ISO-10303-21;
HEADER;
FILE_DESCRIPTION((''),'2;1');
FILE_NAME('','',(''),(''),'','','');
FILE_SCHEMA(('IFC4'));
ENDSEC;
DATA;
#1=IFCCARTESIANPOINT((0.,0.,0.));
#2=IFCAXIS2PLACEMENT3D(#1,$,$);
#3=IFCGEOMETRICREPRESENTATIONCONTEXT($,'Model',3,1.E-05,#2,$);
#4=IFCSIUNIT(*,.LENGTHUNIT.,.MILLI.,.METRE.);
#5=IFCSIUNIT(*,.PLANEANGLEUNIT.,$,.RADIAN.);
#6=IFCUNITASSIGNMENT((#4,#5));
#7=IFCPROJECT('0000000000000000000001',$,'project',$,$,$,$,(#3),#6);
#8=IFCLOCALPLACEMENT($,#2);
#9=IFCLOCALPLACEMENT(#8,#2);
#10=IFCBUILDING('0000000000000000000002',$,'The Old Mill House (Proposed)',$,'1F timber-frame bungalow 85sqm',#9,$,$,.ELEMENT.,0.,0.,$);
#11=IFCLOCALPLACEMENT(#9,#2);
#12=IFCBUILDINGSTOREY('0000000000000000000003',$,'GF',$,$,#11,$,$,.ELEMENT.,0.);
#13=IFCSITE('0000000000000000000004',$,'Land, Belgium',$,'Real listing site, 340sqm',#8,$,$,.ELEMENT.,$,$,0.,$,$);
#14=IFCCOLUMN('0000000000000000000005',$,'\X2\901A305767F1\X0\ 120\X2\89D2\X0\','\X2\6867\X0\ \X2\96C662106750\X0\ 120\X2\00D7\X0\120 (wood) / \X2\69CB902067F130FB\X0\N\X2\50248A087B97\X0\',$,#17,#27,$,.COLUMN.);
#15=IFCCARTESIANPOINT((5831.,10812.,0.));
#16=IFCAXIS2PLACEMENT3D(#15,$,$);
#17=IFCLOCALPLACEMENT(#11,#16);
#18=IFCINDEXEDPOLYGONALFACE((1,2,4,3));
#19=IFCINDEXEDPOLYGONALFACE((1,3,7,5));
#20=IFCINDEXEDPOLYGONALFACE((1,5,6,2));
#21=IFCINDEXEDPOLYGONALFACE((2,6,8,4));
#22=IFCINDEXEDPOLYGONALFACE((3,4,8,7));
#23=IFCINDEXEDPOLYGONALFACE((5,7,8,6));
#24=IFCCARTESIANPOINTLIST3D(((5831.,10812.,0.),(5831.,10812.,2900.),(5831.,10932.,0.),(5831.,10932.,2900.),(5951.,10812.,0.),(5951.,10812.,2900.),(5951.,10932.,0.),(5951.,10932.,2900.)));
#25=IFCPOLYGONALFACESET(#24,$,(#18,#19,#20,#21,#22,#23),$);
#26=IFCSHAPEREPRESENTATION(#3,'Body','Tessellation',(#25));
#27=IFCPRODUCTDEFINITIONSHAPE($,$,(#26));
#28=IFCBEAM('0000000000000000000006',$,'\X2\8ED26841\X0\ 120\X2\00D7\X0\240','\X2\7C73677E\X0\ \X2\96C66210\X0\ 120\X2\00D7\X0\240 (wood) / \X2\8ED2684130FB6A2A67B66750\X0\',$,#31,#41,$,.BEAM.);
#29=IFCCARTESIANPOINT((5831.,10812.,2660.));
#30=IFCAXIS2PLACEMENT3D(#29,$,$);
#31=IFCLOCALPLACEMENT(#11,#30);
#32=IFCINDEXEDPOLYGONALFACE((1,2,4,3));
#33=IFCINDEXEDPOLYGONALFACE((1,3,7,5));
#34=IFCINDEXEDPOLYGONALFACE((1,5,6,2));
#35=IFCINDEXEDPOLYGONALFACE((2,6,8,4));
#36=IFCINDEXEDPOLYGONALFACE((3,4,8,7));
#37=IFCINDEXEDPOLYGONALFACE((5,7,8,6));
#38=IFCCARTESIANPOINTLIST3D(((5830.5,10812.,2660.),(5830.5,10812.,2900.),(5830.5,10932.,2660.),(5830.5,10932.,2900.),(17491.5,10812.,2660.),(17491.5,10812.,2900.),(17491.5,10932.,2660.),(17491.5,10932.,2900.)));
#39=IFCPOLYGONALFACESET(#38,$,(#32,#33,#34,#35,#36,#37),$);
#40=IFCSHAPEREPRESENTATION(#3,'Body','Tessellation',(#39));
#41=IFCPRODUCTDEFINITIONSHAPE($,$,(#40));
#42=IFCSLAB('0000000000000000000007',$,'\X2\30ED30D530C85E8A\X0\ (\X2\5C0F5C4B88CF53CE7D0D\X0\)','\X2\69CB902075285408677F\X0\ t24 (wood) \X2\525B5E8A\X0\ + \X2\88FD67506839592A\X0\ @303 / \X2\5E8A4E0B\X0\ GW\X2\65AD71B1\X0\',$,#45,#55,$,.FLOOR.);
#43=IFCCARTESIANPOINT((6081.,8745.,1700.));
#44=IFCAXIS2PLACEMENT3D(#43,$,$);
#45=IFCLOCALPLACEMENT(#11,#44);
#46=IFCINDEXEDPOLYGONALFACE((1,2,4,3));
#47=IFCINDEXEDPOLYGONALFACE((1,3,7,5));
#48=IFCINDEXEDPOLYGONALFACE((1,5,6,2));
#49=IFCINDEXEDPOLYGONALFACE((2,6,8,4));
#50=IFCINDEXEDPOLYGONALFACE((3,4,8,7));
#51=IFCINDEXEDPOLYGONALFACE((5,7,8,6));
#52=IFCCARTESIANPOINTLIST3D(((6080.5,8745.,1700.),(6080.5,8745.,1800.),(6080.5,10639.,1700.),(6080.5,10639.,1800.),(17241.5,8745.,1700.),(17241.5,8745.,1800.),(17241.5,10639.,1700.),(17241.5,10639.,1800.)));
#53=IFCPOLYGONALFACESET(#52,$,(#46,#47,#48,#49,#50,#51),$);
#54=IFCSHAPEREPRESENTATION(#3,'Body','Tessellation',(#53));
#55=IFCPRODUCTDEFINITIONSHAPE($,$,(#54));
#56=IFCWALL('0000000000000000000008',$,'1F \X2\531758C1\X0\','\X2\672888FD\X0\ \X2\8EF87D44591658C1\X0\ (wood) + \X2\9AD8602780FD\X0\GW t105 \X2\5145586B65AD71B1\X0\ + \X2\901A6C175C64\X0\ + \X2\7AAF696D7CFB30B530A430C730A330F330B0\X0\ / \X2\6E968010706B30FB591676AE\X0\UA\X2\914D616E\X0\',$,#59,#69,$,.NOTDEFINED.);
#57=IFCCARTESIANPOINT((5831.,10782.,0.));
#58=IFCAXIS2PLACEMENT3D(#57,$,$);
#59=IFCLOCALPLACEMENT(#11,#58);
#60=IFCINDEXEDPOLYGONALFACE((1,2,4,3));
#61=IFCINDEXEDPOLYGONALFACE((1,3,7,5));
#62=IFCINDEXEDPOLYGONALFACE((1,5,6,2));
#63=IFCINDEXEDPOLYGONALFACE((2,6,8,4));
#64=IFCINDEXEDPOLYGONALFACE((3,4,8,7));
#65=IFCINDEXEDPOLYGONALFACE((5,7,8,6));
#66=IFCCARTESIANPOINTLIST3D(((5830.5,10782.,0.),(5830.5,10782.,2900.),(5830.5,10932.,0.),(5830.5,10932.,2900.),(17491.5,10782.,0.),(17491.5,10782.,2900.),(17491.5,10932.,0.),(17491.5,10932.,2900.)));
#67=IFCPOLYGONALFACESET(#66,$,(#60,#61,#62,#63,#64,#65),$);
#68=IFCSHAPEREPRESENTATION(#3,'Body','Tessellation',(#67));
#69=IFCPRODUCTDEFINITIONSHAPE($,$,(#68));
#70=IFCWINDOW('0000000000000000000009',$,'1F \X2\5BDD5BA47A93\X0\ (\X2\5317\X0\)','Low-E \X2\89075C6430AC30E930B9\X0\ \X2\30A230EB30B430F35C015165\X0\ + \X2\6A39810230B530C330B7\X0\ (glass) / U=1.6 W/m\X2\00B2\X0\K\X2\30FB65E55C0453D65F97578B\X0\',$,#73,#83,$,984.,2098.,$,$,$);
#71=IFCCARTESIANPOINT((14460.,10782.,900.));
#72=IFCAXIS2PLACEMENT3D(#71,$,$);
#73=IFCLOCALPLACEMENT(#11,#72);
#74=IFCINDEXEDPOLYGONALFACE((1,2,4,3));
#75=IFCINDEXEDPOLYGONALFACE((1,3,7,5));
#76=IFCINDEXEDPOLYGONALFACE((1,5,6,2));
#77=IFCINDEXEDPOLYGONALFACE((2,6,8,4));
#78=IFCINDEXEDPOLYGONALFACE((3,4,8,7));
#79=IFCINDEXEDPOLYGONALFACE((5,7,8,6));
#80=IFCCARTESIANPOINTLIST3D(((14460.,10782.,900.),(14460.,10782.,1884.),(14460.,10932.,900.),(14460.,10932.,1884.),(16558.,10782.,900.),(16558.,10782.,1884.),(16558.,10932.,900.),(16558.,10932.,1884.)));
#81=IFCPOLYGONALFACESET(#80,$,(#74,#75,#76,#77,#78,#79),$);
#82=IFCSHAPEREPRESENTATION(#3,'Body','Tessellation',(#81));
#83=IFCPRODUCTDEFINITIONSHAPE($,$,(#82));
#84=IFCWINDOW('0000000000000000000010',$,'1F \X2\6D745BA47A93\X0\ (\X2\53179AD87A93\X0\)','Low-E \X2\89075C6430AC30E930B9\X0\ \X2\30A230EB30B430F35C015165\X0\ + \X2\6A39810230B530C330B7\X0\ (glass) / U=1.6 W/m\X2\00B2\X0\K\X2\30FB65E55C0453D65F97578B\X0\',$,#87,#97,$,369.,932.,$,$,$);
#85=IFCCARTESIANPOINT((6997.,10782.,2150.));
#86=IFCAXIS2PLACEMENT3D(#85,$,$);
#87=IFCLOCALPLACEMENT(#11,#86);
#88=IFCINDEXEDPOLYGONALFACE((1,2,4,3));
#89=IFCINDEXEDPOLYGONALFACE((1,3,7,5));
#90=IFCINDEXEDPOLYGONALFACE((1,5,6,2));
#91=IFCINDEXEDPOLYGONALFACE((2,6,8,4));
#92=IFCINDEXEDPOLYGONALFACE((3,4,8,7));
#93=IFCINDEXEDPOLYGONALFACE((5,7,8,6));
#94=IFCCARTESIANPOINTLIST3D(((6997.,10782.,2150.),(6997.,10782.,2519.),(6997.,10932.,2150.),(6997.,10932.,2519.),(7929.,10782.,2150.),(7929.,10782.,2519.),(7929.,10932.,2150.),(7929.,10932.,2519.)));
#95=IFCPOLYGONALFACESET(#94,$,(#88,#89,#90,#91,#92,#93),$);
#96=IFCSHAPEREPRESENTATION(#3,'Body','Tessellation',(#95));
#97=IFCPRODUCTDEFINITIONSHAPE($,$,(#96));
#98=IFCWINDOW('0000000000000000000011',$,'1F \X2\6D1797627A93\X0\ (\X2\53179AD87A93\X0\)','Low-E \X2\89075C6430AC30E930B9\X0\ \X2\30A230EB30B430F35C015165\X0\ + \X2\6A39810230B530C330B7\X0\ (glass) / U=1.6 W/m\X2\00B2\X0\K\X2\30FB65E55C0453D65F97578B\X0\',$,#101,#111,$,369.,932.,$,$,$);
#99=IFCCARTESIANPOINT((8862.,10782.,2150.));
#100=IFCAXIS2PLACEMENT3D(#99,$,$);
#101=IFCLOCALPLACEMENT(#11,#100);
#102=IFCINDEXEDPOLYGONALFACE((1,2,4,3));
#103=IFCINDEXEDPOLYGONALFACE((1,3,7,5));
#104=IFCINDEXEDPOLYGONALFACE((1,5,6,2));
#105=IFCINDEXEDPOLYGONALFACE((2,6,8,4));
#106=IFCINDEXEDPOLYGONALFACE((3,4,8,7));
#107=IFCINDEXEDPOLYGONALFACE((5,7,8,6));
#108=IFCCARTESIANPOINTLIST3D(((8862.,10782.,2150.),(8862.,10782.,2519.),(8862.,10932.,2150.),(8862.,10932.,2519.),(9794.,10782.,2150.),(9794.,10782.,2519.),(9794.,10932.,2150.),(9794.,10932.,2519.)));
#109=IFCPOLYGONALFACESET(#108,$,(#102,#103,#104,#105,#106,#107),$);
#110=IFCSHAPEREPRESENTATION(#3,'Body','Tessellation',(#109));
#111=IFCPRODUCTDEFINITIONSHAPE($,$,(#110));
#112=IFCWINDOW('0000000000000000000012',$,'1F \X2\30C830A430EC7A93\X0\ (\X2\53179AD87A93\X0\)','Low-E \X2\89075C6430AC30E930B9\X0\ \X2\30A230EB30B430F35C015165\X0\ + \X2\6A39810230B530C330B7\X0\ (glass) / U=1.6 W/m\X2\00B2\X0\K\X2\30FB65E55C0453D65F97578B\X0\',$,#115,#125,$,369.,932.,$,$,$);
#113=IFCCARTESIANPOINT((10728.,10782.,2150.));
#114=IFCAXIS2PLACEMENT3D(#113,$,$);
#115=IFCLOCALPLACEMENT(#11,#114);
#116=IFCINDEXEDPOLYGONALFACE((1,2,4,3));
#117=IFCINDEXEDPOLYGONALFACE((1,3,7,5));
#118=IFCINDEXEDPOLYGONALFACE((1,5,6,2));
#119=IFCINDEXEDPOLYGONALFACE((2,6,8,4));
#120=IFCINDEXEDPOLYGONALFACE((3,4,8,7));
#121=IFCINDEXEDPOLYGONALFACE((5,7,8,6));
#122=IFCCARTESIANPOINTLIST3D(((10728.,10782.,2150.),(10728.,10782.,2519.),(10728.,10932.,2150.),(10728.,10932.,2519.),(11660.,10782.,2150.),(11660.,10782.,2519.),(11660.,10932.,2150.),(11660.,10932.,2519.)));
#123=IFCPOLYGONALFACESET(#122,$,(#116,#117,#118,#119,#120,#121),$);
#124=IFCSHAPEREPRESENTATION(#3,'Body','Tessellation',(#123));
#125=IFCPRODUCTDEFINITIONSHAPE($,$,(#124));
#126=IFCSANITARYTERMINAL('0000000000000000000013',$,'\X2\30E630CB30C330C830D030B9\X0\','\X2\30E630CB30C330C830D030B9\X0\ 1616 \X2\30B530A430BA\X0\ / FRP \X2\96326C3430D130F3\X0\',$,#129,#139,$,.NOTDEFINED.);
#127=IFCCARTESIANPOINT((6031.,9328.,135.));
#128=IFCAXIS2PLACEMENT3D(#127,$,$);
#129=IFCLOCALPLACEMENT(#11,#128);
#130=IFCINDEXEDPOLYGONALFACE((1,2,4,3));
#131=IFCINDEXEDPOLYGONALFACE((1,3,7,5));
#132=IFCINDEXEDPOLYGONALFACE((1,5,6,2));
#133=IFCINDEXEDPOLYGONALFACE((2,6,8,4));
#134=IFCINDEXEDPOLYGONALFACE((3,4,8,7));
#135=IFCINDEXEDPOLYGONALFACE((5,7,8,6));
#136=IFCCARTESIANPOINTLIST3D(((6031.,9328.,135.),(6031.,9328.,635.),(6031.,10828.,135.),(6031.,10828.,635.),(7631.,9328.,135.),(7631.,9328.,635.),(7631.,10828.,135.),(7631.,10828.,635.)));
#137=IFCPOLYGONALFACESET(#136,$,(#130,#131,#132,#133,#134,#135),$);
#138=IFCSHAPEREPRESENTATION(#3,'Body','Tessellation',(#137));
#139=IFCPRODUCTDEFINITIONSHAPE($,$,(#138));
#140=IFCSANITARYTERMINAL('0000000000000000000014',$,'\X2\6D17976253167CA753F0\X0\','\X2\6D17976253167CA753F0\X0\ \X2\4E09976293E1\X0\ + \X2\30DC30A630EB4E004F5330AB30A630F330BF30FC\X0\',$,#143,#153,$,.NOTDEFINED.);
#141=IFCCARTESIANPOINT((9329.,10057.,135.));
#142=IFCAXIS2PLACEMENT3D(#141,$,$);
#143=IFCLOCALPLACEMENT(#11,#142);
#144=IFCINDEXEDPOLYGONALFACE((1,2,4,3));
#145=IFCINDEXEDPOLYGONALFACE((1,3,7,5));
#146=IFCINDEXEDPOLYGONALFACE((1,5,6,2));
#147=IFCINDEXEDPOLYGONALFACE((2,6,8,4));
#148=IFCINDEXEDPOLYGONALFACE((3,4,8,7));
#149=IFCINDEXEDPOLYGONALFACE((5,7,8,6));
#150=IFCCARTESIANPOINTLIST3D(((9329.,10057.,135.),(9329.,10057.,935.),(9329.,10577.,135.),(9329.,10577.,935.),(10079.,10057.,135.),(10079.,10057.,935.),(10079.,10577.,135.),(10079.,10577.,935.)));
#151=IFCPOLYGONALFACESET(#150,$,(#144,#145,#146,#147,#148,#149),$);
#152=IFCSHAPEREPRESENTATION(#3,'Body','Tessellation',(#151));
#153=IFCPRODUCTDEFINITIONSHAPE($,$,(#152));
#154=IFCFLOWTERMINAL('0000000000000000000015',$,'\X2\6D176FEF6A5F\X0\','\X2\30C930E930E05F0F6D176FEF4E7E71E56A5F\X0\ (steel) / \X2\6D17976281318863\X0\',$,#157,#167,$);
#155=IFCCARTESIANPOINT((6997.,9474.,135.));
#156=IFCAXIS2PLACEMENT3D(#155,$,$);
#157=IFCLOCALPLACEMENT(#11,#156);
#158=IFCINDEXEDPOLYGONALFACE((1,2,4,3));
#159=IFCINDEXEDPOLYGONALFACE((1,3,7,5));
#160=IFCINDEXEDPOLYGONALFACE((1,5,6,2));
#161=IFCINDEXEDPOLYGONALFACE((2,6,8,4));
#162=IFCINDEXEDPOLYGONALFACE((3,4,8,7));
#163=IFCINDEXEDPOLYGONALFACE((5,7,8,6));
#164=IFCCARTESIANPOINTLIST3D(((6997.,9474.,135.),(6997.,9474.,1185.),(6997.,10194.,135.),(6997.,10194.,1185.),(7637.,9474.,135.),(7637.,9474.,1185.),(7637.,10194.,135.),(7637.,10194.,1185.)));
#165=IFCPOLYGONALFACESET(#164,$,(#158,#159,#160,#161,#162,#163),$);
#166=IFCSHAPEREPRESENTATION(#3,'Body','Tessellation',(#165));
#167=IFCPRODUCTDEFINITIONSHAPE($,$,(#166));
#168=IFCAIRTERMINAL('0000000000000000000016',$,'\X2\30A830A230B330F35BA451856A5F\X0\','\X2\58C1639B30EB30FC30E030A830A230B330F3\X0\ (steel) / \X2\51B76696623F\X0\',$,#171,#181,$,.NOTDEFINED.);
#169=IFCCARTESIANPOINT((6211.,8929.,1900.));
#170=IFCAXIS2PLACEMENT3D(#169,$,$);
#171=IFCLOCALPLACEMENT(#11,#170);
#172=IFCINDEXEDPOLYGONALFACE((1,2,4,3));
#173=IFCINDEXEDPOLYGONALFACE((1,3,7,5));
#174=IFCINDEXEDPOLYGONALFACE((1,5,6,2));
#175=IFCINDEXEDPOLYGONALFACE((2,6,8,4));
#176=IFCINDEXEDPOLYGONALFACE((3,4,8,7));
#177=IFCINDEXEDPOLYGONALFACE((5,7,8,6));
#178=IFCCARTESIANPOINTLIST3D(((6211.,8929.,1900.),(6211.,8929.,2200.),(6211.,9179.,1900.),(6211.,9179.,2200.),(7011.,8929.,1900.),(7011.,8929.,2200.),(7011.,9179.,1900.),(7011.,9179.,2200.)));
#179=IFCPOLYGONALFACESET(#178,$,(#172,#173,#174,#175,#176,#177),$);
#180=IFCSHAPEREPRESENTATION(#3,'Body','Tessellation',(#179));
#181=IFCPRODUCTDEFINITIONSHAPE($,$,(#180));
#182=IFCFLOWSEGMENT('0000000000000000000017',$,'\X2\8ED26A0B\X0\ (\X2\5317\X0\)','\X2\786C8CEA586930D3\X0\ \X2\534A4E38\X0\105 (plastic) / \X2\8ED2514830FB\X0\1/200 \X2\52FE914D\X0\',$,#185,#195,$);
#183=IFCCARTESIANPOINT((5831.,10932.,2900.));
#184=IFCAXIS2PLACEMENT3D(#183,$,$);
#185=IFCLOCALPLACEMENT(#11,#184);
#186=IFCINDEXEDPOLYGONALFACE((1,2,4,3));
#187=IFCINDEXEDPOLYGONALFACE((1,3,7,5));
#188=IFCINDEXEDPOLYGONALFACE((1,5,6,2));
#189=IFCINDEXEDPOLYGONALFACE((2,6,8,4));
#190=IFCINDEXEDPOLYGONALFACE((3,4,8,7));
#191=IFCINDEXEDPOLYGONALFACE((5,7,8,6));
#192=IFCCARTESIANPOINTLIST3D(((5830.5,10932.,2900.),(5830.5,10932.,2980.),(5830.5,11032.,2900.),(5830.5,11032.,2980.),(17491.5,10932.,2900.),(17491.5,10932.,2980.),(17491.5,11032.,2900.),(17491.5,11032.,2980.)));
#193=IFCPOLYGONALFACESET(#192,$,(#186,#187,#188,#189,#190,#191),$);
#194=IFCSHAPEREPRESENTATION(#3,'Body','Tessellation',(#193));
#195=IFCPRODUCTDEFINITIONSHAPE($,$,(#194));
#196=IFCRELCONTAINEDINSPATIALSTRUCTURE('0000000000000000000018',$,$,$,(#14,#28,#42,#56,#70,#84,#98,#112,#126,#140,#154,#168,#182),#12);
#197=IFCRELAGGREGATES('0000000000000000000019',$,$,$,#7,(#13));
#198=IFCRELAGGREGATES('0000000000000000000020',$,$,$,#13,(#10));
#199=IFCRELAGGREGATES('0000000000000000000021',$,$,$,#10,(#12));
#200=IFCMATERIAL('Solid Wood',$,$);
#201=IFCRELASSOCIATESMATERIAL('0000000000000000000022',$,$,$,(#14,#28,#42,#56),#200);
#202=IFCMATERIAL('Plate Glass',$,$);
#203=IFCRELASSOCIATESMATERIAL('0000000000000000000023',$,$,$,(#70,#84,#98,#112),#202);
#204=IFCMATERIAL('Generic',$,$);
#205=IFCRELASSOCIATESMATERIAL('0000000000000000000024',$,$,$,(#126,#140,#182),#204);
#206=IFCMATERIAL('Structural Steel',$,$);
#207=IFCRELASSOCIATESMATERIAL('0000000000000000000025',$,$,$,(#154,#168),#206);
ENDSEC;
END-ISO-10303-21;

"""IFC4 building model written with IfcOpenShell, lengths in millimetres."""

from ifc_helpers import new_model, si_unit, frame, frame_2d, origin, place, context, project, spatial, rectangle, extrude, material, element, fill, save


model = new_model("IFC4")

# Units and contexts
model_context = context("Model", 3, precision=1e-05, world=origin())
ifc_project = project(units=[si_unit("LENGTHUNIT", "METRE", prefix="MILLI"), si_unit("PLANEANGLEUNIT", "RADIAN")], contexts=[model_context])

# Site, building, storey
site_placement = place(None, origin())
site = spatial("IfcSite", under=ifc_project, at=site_placement, Name="Land, Belgium", ObjectType="Real listing site, 340sqm", CompositionType="ELEMENT", RefElevation=0.0)
building_placement = place(site_placement, origin())
building = spatial("IfcBuilding", under=site, at=building_placement, Name="The Old Mill House (Proposed)", ObjectType="1F timber-frame bungalow 85sqm", CompositionType="ELEMENT", ElevationOfRefHeight=0.0, ElevationOfTerrain=0.0)
storey_placement = place(building_placement, origin())
storey = spatial("IfcBuildingStorey", under=building, at=storey_placement, Name="GF", CompositionType="ELEMENT", Elevation=0.0)

# Column
ifc_material_1 = material(Name="Solid Wood")
column_1_placement = place(storey_placement, frame((5831.0, 10812.0, 0.0)))
element("IfcColumn", 1, at=column_1_placement, inside=storey, material=ifc_material_1, Name="通し柱 120角", Description="桧 集成材 120×120 (wood) / 構造柱・N値計算", PredefinedType="COLUMN", context=model_context, shape_type="SweptSolid", body=[
    extrude(rectangle(XDim=120.0, YDim=120.0, at=frame_2d((60.0, 60.0))), frame((5831.0, 10812.0, 0.0)), (0.0, 0.0, 1.0), 2900.0),
])

# Beam
beam_1_placement = place(storey_placement, frame((5831.0, 10812.0, 2660.0)))
element("IfcBeam", 2, at=beam_1_placement, inside=storey, material=ifc_material_1, Name="軒桁 120×240", Description="米松 集成 120×240 (wood) / 軒桁・横架材", PredefinedType="BEAM", context=model_context, shape_type="SweptSolid", body=[
    extrude(rectangle(XDim=11661.0, YDim=120.0, at=frame_2d((5830.0, 60.0))), frame((5831.0, 10812.0, 2660.0)), (0.0, 0.0, 1.0), 240.0),
])

# Slab
slab_placement = place(storey_placement, frame((6081.0, 8745.0, 1700.0)))
element("IfcSlab", 3, at=slab_placement, inside=storey, material=ifc_material_1, Name="ロフト床 (小屋裏収納)", Description="構造用合板 t24 (wood) 剛床 + 製材根太 @303 / 床下 GW断熱", PredefinedType="FLOOR", context=model_context, shape_type="SweptSolid", body=[
    extrude(rectangle(XDim=11161.0, YDim=1894.0, at=frame_2d((5580.0, 947.0))), frame((6081.0, 8745.0, 1700.0)), (0.0, 0.0, 1.0), 100.0),
])

# Wall, openings, windows
wall_1_placement = place(storey_placement, frame((5831.0, 10782.0, 0.0)))
wall_1 = element("IfcWall", 4, at=wall_1_placement, inside=storey, material=ifc_material_1, Name="1F 北壁", Description="木製 軸組外壁 (wood) + 高性能GW t105 充填断熱 + 通気層 + 窯業系サイディング / 準耐火・外皮UA配慮", PredefinedType="NOTDEFINED", context=model_context, shape_type="SweptSolid", body=[
    extrude(rectangle(XDim=11661.0, YDim=150.0, at=frame_2d((5830.0, 75.0))), frame((5831.0, 10782.0, 0.0)), (0.0, 0.0, 1.0), 2900.0),
])
opening_1_placement = place(storey_placement, frame((14460.0, 10782.0, 900.0)))
opening_1 = element("IfcOpeningElement", 5, at=opening_1_placement, cuts=wall_1, PredefinedType="NOTDEFINED", context=model_context, shape_type="SweptSolid", body=[
    extrude(rectangle(XDim=2098.0, YDim=150.0, at=frame_2d((1049.0, 75.0))), frame((14460.0, 10782.0, 900.0)), (0.0, 0.0, 1.0), 984.0),
])
opening_2_placement = place(storey_placement, frame((6997.0, 10782.0, 2150.0)))
opening_2 = element("IfcOpeningElement", 6, at=opening_2_placement, cuts=wall_1, PredefinedType="NOTDEFINED", context=model_context, shape_type="SweptSolid", body=[
    extrude(rectangle(XDim=932.0, YDim=150.0, at=frame_2d((466.0, 75.0))), frame((6997.0, 10782.0, 2150.0)), (0.0, 0.0, 1.0), 369.0),
])
opening_3_placement = place(storey_placement, frame((8862.0, 10782.0, 2150.0)))
opening_3 = element("IfcOpeningElement", 7, at=opening_3_placement, cuts=wall_1, PredefinedType="NOTDEFINED", context=model_context, shape_type="SweptSolid", body=[
    extrude(rectangle(XDim=932.0, YDim=150.0, at=frame_2d((466.0, 75.0))), frame((8862.0, 10782.0, 2150.0)), (0.0, 0.0, 1.0), 369.0),
])
opening_4_placement = place(storey_placement, frame((10728.0, 10782.0, 2150.0)))
opening_4 = element("IfcOpeningElement", 8, at=opening_4_placement, cuts=wall_1, PredefinedType="NOTDEFINED", context=model_context, shape_type="SweptSolid", body=[
    extrude(rectangle(XDim=932.0, YDim=150.0, at=frame_2d((466.0, 75.0))), frame((10728.0, 10782.0, 2150.0)), (0.0, 0.0, 1.0), 369.0),
])
ifc_material_2 = material(Name="Plate Glass")
window_1_placement = place(storey_placement, frame((14460.0, 10782.0, 900.0)))
window_1 = element("IfcWindow", 9, at=window_1_placement, inside=storey, material=ifc_material_2, Name="1F 寝室窓 (北)", Description="Low-E 複層ガラス アルゴン封入 + 樹脂サッシ (glass) / U=1.6 W/m²K・日射取得型", OverallHeight=984.0, OverallWidth=2098.0, context=model_context, shape_type="SweptSolid", body=[
    extrude(rectangle(XDim=2098.0, YDim=150.0, at=frame_2d((1049.0, 75.0))), frame((14460.0, 10782.0, 900.0)), (0.0, 0.0, 1.0), 984.0),
])
fill(opening_1, window_1)
window_2_placement = place(storey_placement, frame((6997.0, 10782.0, 2150.0)))
window_2 = element("IfcWindow", 10, at=window_2_placement, inside=storey, material=ifc_material_2, Name="1F 浴室窓 (北高窓)", Description="Low-E 複層ガラス アルゴン封入 + 樹脂サッシ (glass) / U=1.6 W/m²K・日射取得型", OverallHeight=369.0, OverallWidth=932.0, context=model_context, shape_type="SweptSolid", body=[
    extrude(rectangle(XDim=932.0, YDim=150.0, at=frame_2d((466.0, 75.0))), frame((6997.0, 10782.0, 2150.0)), (0.0, 0.0, 1.0), 369.0),
])
fill(opening_2, window_2)
window_3_placement = place(storey_placement, frame((8862.0, 10782.0, 2150.0)))
window_3 = element("IfcWindow", 11, at=window_3_placement, inside=storey, material=ifc_material_2, Name="1F 洗面窓 (北高窓)", Description="Low-E 複層ガラス アルゴン封入 + 樹脂サッシ (glass) / U=1.6 W/m²K・日射取得型", OverallHeight=369.0, OverallWidth=932.0, context=model_context, shape_type="SweptSolid", body=[
    extrude(rectangle(XDim=932.0, YDim=150.0, at=frame_2d((466.0, 75.0))), frame((8862.0, 10782.0, 2150.0)), (0.0, 0.0, 1.0), 369.0),
])
fill(opening_3, window_3)
window_4_placement = place(storey_placement, frame((10728.0, 10782.0, 2150.0)))
window_4 = element("IfcWindow", 12, at=window_4_placement, inside=storey, material=ifc_material_2, Name="1F トイレ窓 (北高窓)", Description="Low-E 複層ガラス アルゴン封入 + 樹脂サッシ (glass) / U=1.6 W/m²K・日射取得型", OverallHeight=369.0, OverallWidth=932.0, context=model_context, shape_type="SweptSolid", body=[
    extrude(rectangle(XDim=932.0, YDim=150.0, at=frame_2d((466.0, 75.0))), frame((10728.0, 10782.0, 2150.0)), (0.0, 0.0, 1.0), 369.0),
])
fill(opening_4, window_4)

# Shared definitions
ifc_material_3 = material(Name="Generic")

# Sanitary terminals
sanitary_terminal_1_placement = place(storey_placement, frame((6031.0, 9328.0, 135.0)))
element("IfcSanitaryTerminal", 13, at=sanitary_terminal_1_placement, inside=storey, material=ifc_material_3, Name="ユニットバス", Description="ユニットバス 1616 サイズ / FRP 防水パン", PredefinedType="NOTDEFINED", context=model_context, shape_type="SweptSolid", body=[
    extrude(rectangle(XDim=1600.0, YDim=1500.0, at=frame_2d((800.0, 750.0))), frame((6031.0, 9328.0, 135.0)), (0.0, 0.0, 1.0), 500.0),
])
sanitary_terminal_2_placement = place(storey_placement, frame((9329.0, 10057.0, 135.0)))
element("IfcSanitaryTerminal", 14, at=sanitary_terminal_2_placement, inside=storey, material=ifc_material_3, Name="洗面化粧台", Description="洗面化粧台 三面鏡 + ボウル一体カウンター", PredefinedType="NOTDEFINED", context=model_context, shape_type="SweptSolid", body=[
    extrude(rectangle(XDim=750.0, YDim=520.0, at=frame_2d((375.0, 260.0))), frame((9329.0, 10057.0, 135.0)), (0.0, 0.0, 1.0), 800.0),
])

# Flow terminal
ifc_material_4 = material(Name="Structural Steel")
flow_terminal_placement = place(storey_placement, frame((6997.0, 9474.0, 135.0)))
element("IfcFlowTerminal", 15, at=flow_terminal_placement, inside=storey, material=ifc_material_4, Name="洗濯機", Description="ドラム式洗濯乾燥機 (steel) / 洗面脱衣", context=model_context, shape_type="SweptSolid", body=[
    extrude(rectangle(XDim=640.0, YDim=720.0, at=frame_2d((320.0, 360.0))), frame((6997.0, 9474.0, 135.0)), (0.0, 0.0, 1.0), 1050.0),
])

# Air terminal
air_terminal_placement = place(storey_placement, frame((6211.0, 8929.0, 1900.0)))
element("IfcAirTerminal", 16, at=air_terminal_placement, inside=storey, material=ifc_material_4, Name="エアコン室内機", Description="壁掛ルームエアコン (steel) / 冷暖房", PredefinedType="NOTDEFINED", context=model_context, shape_type="SweptSolid", body=[
    extrude(rectangle(XDim=800.0, YDim=250.0, at=frame_2d((400.0, 125.0))), frame((6211.0, 8929.0, 1900.0)), (0.0, 0.0, 1.0), 300.0),
])

# Flow segment
flow_segment_1_placement = place(storey_placement, frame((5831.0, 10932.0, 2900.0)))
element("IfcFlowSegment", 17, at=flow_segment_1_placement, inside=storey, material=ifc_material_3, Name="軒樋 (北)", Description="硬質塩ビ 半丸105 (plastic) / 軒先・1/200 勾配", context=model_context, shape_type="SweptSolid", body=[
    extrude(rectangle(XDim=11661.0, YDim=100.0, at=frame_2d((5830.0, 50.0))), frame((5831.0, 10932.0, 2900.0)), (0.0, 0.0, 1.0), 80.0),
])

save(model, "model.ifc")
